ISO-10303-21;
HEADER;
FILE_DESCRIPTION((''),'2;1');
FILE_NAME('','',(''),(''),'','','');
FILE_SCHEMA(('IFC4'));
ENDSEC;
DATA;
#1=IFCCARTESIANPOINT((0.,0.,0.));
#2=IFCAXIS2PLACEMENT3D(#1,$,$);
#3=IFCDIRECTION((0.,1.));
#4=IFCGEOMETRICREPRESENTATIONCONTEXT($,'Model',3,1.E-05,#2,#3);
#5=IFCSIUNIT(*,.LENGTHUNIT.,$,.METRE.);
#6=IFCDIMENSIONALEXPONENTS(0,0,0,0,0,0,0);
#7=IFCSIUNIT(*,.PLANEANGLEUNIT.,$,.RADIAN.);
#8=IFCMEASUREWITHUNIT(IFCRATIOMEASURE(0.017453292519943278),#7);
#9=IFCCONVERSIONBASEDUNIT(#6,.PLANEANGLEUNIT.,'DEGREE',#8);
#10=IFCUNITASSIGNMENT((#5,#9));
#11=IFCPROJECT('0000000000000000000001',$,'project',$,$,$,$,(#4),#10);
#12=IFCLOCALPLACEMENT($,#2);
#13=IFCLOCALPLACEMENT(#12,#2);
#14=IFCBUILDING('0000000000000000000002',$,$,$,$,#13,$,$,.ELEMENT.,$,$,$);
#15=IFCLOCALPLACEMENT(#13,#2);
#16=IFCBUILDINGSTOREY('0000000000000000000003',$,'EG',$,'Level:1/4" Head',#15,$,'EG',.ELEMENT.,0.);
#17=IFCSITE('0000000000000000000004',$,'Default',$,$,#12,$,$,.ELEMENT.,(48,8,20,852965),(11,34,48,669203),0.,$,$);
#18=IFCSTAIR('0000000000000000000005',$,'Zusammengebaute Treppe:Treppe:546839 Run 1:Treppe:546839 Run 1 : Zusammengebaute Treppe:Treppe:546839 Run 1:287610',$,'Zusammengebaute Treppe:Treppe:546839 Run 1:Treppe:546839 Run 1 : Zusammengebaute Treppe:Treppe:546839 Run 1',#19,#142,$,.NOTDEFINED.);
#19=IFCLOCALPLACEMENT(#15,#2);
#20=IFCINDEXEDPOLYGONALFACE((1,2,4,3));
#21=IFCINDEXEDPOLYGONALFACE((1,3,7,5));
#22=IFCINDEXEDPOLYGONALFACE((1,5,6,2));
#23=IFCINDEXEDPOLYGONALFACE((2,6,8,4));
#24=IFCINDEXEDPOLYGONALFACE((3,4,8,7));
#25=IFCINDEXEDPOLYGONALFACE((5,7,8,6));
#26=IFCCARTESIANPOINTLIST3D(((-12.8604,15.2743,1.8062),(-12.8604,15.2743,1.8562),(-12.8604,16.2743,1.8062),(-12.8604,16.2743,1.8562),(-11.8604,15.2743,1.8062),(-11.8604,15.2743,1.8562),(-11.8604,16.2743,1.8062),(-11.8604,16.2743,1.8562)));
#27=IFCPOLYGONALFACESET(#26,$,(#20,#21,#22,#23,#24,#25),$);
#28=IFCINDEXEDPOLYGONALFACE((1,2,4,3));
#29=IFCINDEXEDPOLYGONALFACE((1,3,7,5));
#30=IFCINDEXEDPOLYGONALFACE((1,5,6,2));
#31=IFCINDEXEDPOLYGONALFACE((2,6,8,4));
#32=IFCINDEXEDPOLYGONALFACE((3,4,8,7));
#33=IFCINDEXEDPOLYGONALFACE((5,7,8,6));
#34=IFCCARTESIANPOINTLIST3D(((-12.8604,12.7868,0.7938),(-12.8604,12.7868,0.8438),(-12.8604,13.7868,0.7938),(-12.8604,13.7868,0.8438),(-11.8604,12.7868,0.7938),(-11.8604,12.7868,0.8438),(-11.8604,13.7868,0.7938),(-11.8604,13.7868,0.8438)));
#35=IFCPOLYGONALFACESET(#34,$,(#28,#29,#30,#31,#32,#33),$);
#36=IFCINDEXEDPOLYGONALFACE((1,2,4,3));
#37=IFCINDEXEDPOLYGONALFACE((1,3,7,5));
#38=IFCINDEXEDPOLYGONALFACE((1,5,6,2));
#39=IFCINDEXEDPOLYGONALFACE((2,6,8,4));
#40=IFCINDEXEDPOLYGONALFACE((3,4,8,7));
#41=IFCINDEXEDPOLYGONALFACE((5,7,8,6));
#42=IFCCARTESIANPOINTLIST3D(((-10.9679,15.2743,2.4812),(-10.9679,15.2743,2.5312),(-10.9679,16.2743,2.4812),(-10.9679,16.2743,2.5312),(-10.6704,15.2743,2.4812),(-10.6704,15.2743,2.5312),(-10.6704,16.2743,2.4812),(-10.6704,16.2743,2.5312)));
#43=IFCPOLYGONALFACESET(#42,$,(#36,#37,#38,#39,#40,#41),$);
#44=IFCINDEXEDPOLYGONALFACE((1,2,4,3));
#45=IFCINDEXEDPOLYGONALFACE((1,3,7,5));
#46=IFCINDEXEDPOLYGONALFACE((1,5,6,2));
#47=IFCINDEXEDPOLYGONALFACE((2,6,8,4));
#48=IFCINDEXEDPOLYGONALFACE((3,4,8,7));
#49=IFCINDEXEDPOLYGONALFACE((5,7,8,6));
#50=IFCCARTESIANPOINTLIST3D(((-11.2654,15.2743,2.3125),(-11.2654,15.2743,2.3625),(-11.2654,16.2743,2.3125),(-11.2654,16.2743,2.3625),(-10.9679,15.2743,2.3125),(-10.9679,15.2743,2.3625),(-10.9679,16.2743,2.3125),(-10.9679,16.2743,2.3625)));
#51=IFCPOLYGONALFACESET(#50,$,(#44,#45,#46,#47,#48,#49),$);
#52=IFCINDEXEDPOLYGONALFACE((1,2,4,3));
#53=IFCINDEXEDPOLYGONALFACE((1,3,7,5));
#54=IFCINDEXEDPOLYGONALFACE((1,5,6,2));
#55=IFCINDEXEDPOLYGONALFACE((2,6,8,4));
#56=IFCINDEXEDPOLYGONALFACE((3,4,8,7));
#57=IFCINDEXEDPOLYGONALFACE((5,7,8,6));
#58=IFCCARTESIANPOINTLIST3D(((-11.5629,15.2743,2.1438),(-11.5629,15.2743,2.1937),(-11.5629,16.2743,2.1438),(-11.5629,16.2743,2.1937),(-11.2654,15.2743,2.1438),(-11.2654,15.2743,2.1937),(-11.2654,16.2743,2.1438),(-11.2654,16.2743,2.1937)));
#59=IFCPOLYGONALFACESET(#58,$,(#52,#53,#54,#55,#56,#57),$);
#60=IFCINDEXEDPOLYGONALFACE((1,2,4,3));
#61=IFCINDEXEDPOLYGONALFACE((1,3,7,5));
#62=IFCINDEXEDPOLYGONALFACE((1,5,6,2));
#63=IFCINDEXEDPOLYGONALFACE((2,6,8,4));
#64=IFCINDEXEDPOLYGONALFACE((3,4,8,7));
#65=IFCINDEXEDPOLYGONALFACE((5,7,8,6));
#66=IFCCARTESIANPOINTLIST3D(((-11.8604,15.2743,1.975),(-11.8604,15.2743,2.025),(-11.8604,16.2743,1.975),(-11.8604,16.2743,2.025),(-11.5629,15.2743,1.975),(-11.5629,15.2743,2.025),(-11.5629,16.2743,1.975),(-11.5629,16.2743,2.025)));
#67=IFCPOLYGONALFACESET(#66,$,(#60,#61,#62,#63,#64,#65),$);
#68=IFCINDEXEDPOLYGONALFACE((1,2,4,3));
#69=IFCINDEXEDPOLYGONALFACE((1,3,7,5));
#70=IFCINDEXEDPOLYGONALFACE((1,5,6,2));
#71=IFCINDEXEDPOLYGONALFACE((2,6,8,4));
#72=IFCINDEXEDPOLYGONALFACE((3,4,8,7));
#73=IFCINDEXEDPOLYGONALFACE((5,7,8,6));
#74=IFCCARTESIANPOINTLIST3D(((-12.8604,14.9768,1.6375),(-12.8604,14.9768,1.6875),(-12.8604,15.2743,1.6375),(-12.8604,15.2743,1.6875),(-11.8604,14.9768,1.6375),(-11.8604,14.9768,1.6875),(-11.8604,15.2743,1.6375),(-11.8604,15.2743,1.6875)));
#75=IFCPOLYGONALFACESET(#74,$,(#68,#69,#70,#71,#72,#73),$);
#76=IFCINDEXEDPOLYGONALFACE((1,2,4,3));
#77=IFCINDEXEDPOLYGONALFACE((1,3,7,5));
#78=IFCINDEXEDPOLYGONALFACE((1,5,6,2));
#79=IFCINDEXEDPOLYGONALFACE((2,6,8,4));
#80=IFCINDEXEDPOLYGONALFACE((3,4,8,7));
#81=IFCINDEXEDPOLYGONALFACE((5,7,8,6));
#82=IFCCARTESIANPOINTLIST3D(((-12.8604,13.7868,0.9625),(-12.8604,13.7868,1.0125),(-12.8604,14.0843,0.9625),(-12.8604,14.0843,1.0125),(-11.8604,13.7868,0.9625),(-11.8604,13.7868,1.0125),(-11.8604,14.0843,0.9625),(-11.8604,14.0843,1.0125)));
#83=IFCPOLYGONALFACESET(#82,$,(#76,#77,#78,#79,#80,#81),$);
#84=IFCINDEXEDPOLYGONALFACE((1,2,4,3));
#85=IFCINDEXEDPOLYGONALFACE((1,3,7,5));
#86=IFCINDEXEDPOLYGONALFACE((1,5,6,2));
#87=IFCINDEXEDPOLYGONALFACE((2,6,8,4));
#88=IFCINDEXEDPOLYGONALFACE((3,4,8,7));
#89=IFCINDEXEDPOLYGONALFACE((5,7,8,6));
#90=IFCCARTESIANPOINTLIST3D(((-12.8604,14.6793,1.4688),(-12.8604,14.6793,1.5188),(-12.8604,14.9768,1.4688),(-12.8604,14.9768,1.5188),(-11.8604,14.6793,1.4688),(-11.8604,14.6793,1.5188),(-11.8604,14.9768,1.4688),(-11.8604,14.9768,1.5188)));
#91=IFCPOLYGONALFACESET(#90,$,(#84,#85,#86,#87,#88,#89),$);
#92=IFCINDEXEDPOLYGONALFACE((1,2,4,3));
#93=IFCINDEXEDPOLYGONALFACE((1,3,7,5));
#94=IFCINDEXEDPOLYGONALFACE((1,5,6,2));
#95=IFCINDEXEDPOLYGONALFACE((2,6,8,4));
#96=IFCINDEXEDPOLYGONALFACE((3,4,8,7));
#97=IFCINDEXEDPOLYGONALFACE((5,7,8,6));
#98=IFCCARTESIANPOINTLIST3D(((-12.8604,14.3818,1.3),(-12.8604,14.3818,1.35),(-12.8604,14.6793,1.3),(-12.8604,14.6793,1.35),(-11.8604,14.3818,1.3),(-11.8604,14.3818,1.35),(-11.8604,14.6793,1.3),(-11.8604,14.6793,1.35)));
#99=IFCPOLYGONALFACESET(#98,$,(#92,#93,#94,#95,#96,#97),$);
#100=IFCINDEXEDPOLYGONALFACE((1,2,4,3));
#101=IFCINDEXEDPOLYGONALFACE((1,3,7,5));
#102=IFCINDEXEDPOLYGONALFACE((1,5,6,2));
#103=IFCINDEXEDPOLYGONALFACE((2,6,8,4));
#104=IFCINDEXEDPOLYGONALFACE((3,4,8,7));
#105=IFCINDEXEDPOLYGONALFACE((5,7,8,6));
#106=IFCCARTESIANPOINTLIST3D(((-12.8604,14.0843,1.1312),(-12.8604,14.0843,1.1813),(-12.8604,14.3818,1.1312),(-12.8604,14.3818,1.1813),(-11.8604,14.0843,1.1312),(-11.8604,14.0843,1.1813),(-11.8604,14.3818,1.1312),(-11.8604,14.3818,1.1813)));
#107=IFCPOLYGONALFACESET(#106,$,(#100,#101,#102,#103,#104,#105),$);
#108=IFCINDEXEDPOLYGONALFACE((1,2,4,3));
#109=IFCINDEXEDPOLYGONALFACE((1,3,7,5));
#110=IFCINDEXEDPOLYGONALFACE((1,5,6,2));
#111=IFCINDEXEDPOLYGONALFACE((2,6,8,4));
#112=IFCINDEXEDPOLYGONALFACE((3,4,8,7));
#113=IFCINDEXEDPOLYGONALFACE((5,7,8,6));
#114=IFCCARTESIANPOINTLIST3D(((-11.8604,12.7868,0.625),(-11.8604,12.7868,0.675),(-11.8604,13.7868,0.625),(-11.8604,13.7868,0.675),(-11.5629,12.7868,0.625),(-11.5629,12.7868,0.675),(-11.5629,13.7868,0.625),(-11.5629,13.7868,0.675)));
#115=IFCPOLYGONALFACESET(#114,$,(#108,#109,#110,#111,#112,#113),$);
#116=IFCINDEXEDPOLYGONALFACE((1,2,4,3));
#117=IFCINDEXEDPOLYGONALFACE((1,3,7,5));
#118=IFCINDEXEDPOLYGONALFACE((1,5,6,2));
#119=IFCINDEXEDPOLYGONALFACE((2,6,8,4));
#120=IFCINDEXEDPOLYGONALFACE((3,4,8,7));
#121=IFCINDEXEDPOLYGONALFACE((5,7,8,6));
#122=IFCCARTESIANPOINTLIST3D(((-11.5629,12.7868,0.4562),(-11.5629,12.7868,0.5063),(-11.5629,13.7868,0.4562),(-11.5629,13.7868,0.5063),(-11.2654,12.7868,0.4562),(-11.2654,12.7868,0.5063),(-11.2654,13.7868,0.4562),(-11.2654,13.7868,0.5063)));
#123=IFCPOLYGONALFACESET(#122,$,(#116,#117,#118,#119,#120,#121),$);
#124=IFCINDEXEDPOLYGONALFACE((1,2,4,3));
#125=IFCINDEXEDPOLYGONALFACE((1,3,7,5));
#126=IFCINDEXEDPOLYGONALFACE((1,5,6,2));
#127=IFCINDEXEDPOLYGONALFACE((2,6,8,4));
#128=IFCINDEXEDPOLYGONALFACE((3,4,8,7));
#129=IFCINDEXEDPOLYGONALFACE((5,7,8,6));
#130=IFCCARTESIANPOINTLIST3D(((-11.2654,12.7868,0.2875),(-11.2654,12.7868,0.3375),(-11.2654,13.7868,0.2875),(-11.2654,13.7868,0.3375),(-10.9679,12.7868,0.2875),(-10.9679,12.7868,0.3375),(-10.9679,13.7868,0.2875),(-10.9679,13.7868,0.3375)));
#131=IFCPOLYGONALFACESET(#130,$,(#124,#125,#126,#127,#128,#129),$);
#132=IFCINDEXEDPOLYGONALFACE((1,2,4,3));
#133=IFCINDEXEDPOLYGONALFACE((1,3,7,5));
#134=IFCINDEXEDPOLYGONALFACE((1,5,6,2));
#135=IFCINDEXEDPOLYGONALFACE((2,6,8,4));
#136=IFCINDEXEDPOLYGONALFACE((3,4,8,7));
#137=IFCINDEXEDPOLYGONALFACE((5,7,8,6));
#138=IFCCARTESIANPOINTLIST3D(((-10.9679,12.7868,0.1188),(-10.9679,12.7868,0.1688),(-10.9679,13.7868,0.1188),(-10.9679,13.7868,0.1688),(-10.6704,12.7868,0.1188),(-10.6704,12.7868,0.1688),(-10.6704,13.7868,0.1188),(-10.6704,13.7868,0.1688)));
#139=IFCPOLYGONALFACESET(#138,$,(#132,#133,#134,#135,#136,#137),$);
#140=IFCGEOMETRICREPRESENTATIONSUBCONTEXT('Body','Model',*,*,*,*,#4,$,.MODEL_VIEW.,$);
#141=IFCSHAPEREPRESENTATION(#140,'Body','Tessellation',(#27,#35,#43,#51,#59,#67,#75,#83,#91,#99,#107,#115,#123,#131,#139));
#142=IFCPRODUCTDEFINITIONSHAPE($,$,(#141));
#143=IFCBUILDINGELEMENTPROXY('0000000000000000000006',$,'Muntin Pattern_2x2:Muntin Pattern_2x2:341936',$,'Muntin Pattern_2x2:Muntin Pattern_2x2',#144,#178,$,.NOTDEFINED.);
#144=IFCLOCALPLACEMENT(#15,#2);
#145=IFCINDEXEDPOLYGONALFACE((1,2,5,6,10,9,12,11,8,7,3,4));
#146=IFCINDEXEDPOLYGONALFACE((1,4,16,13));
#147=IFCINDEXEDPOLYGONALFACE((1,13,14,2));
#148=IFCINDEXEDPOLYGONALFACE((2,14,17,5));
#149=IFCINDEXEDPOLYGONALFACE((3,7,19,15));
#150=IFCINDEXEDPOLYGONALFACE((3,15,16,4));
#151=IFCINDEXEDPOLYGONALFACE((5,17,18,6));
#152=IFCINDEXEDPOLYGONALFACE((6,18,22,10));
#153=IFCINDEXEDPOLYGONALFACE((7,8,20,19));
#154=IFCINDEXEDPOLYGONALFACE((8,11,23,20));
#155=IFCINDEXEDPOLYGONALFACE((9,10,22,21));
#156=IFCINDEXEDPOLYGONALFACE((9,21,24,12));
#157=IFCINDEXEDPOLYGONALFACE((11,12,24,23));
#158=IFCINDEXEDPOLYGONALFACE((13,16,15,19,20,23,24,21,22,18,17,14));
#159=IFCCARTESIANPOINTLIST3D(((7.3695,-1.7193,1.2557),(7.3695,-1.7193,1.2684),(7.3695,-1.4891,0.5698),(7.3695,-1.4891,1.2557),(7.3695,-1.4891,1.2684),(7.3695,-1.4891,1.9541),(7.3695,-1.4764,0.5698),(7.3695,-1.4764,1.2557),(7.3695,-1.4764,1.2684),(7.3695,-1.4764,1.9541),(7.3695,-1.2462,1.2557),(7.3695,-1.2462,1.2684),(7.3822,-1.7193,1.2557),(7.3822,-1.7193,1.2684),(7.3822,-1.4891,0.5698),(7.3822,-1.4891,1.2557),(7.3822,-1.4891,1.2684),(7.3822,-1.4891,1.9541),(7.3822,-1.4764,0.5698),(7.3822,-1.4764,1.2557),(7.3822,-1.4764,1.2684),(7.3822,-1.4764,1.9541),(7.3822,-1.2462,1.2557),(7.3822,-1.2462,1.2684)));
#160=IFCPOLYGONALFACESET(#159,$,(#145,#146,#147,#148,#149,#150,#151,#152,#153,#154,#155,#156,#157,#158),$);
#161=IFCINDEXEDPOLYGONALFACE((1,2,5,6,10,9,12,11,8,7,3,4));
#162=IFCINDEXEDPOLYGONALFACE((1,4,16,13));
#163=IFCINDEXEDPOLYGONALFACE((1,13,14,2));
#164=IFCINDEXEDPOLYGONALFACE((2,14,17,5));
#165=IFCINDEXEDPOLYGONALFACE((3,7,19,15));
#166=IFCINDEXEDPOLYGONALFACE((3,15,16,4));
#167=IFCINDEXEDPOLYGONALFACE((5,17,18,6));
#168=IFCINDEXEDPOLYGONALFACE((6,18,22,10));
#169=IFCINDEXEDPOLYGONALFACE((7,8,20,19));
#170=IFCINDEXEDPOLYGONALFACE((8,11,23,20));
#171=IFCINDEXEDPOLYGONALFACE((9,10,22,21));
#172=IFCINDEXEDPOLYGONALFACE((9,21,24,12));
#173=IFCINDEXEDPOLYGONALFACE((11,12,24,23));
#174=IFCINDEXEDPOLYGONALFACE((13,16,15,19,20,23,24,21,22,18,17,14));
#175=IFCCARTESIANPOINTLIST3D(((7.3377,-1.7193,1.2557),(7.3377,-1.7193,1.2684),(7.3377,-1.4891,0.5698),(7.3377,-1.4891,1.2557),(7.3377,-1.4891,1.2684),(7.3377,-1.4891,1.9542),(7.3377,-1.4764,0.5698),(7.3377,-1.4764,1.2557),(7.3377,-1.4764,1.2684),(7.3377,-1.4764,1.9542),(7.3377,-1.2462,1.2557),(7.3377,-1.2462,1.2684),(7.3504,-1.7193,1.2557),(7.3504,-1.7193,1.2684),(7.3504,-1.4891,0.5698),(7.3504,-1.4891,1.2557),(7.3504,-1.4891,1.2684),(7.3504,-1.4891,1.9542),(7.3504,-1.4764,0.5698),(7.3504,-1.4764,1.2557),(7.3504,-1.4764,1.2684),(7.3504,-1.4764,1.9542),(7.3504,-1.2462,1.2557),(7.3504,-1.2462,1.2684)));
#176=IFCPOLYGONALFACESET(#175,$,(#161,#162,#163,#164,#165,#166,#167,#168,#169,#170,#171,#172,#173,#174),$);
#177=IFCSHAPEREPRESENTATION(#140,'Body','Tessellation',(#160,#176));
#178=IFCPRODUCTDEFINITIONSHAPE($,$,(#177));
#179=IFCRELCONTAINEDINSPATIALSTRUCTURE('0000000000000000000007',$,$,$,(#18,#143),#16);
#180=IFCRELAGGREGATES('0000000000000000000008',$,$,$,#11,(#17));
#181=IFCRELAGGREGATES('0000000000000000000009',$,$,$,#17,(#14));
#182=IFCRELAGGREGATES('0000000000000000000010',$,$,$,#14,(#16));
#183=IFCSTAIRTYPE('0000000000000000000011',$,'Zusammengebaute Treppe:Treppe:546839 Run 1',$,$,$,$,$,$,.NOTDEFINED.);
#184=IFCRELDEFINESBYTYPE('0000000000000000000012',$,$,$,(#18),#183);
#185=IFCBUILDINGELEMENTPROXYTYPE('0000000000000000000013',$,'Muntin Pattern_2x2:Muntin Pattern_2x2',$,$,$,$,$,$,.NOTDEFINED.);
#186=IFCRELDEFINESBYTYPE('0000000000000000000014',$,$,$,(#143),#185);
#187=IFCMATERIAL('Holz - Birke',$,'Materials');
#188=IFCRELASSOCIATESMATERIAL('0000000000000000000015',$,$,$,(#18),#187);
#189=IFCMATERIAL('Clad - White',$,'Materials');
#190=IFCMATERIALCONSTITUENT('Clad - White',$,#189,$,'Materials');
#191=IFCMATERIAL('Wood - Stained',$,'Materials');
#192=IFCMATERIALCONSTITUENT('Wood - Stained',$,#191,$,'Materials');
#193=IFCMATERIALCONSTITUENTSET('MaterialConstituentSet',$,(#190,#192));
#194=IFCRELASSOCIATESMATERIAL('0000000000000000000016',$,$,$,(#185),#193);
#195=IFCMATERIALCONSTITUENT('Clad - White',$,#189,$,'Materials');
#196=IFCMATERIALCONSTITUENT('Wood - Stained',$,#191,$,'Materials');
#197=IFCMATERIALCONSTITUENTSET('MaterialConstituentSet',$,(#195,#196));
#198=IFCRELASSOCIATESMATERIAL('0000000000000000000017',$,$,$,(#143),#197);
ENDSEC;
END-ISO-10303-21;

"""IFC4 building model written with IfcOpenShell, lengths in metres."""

from ifc_helpers import new_model, entity, si_unit, converted_unit, direction, frame, origin, place, context, subcontext, project, spatial, indexed_curve, outline, extrude, source, transform, mapped, material, constituent, constituent_set, type_object, type_shapes, element, save


model = new_model("IFC4")

# Units and contexts
model_context = context("Model", 3, precision=1e-05, world=origin(), true_north=direction((0.0, 1.0)))
body_context = subcontext(model_context, "Body", "Model", "MODEL_VIEW")
ifc_project = project(units=[si_unit("LENGTHUNIT", "METRE"), converted_unit("PLANEANGLEUNIT", "DEGREE", entity("IfcRatioMeasure", 0.017453292519943278), si_unit("PLANEANGLEUNIT", "RADIAN"), dimensions=[0, 0, 0, 0, 0, 0, 0])], contexts=[model_context])

# Site, building, storey
site_placement = place(None, origin())
site = spatial("IfcSite", under=ifc_project, at=site_placement, Name="Default", CompositionType="ELEMENT", RefLatitude=(48, 8, 20, 852965), RefLongitude=(11, 34, 48, 669203), RefElevation=0.0)
building_placement = place(site_placement, origin())
building = spatial("IfcBuilding", under=site, at=building_placement, CompositionType="ELEMENT")
storey_placement = place(building_placement, origin())
storey = spatial("IfcBuildingStorey", under=building, at=storey_placement, Name="EG", ObjectType="Level:1/4\" Head", LongName="EG", CompositionType="ELEMENT", Elevation=0.0)

# Stair
ifc_material_1 = material(Name="Holz - Birke", Category="Materials")
stair_type_1 = type_object("IfcStairType", Name="Zusammengebaute Treppe:Treppe:546839 Run 1", PredefinedType="NOTDEFINED")
stair_1_placement = place(storey_placement, origin())
element("IfcStair", 1, at=stair_1_placement, inside=storey, type_object=stair_type_1, material=ifc_material_1, Name="Zusammengebaute Treppe:Treppe:546839 Run 1:Treppe:546839 Run 1 : Zusammengebaute Treppe:Treppe:546839 Run 1:287610", ObjectType="Zusammengebaute Treppe:Treppe:546839 Run 1:Treppe:546839 Run 1 : Zusammengebaute Treppe:Treppe:546839 Run 1", PredefinedType="NOTDEFINED", context=body_context, shape_type="SweptSolid", body=[
    extrude(outline(indexed_curve([(-0.5, -0.5), (0.5, -0.5), (0.5, 0.5), (-0.5, 0.5), (-0.5, -0.5)], self_intersect=False)), frame((-12.3604, 15.7743, 1.8063), z_axis=(0.0, 0.0, 1.0), x_axis=(0.0, 1.0, 0.0)), (0.0, 0.0, 1.0), 0.05),
    extrude(outline(indexed_curve([(-0.5, -0.5), (0.5, -0.5), (0.5, 0.5), (-0.5, 0.5), (-0.5, -0.5)], self_intersect=False)), frame((-12.3604, 13.2868, 0.7938), z_axis=(0.0, 0.0, 1.0), x_axis=(-1.0, 0.0, 0.0)), (0.0, 0.0, 1.0), 0.05),
    extrude(outline(indexed_curve([(-0.5, -0.1487), (0.5, -0.1487), (0.5, 0.1487), (-0.5, 0.1487), (-0.5, -0.1487)], self_intersect=False)), frame((-10.8191, 15.7743, 2.4813), z_axis=(0.0, 0.0, 1.0), x_axis=(0.0, -1.0, 0.0)), (0.0, 0.0, 1.0), 0.05),
    extrude(outline(indexed_curve([(-0.5, -0.1487), (0.5, -0.1487), (0.5, 0.1487), (-0.5, 0.1487), (-0.5, -0.1487)], self_intersect=False)), frame((-11.1166, 15.7743, 2.3125), z_axis=(0.0, 0.0, 1.0), x_axis=(0.0, -1.0, 0.0)), (0.0, 0.0, 1.0), 0.05),
    extrude(outline(indexed_curve([(-0.5, -0.1487), (0.5, -0.1487), (0.5, 0.1487), (-0.5, 0.1487), (-0.5, -0.1487)], self_intersect=False)), frame((-11.4141, 15.7743, 2.1437), z_axis=(0.0, 0.0, 1.0), x_axis=(0.0, -1.0, 0.0)), (0.0, 0.0, 1.0), 0.05),
    extrude(outline(indexed_curve([(-0.5, -0.1488), (0.5, -0.1488), (0.5, 0.1488), (-0.5, 0.1488), (-0.5, -0.1488)], self_intersect=False)), frame((-11.7116, 15.7743, 1.975), z_axis=(0.0, 0.0, 1.0), x_axis=(0.0, -1.0, 0.0)), (0.0, 0.0, 1.0), 0.05),
    extrude(outline(indexed_curve([(-0.5, -0.1487), (0.5, -0.1487), (0.5, 0.1488), (-0.5, 0.1488), (-0.5, -0.1487)], self_intersect=False)), frame((-12.3604, 15.1256, 1.6375)), (0.0, 0.0, 1.0), 0.05),
    extrude(outline(indexed_curve([(-0.5, -0.1487), (0.5, -0.1487), (0.5, 0.1488), (-0.5, 0.1488), (-0.5, -0.1487)], self_intersect=False)), frame((-12.3604, 13.9356, 0.9625)), (0.0, 0.0, 1.0), 0.05),
    extrude(outline(indexed_curve([(-0.5, -0.1487), (0.5, -0.1487), (0.5, 0.1488), (-0.5, 0.1488), (-0.5, -0.1487)], self_intersect=False)), frame((-12.3604, 14.8281, 1.4688)), (0.0, 0.0, 1.0), 0.05),
    extrude(outline(indexed_curve([(-0.5, -0.1487), (0.5, -0.1487), (0.5, 0.1488), (-0.5, 0.1488), (-0.5, -0.1487)], self_intersect=False)), frame((-12.3604, 14.5306, 1.3)), (0.0, 0.0, 1.0), 0.05),
    extrude(outline(indexed_curve([(-0.5, -0.1488), (0.5, -0.1488), (0.5, 0.1487), (-0.5, 0.1487), (-0.5, -0.1488)], self_intersect=False)), frame((-12.3604, 14.2331, 1.1313)), (0.0, 0.0, 1.0), 0.05),
    extrude(outline(indexed_curve([(-0.5, -0.1487), (0.5, -0.1487), (0.5, 0.1487), (-0.5, 0.1487), (-0.5, -0.1487)], self_intersect=False)), frame((-11.7116, 13.2868, 0.625), z_axis=(0.0, 0.0, 1.0), x_axis=(0.0, 1.0, 0.0)), (0.0, 0.0, 1.0), 0.05),
    extrude(outline(indexed_curve([(-0.5, -0.1487), (0.5, -0.1487), (0.5, 0.1487), (-0.5, 0.1487), (-0.5, -0.1487)], self_intersect=False)), frame((-11.4141, 13.2868, 0.4563), z_axis=(0.0, 0.0, 1.0), x_axis=(0.0, 1.0, 0.0)), (0.0, 0.0, 1.0), 0.05),
    extrude(outline(indexed_curve([(-0.5, -0.1487), (0.5, -0.1487), (0.5, 0.1487), (-0.5, 0.1487), (-0.5, -0.1487)], self_intersect=False)), frame((-11.1166, 13.2868, 0.2875), z_axis=(0.0, 0.0, 1.0), x_axis=(0.0, 1.0, 0.0)), (0.0, 0.0, 1.0), 0.05),
    extrude(outline(indexed_curve([(-0.5, -0.1488), (0.5, -0.1488), (0.5, 0.1488), (-0.5, 0.1488), (-0.5, -0.1488)], self_intersect=False)), frame((-10.8191, 13.2868, 0.1188), z_axis=(0.0, 0.0, 1.0), x_axis=(0.0, 1.0, 0.0)), (0.0, 0.0, 1.0), 0.05),
])

# Building element proxy
ifc_material_2 = material(Name="Clad - White", Category="Materials")
ifc_constituent_1 = constituent(ifc_material_2, Name="Clad - White", Category="Materials")
ifc_material_3 = material(Name="Wood - Stained", Category="Materials")
ifc_constituent_2 = constituent(ifc_material_3, Name="Wood - Stained", Category="Materials")
ifc_constituent_set_1 = constituent_set(constituents=[ifc_constituent_1, ifc_constituent_2], Name="MaterialConstituentSet")
ifc_constituent_3 = constituent(ifc_material_2, Name="Clad - White", Category="Materials")
ifc_constituent_4 = constituent(ifc_material_3, Name="Wood - Stained", Category="Materials")
ifc_constituent_set_2 = constituent_set(constituents=[ifc_constituent_3, ifc_constituent_4], Name="MaterialConstituentSet")
building_element_proxy_type_1 = type_object("IfcBuildingElementProxyType", Name="Muntin Pattern_2x2:Muntin Pattern_2x2", PredefinedType="NOTDEFINED", material=ifc_constituent_set_2)
shared_shape_1 = source(origin(), body_context, "Body", "SweptSolid", [
    extrude(outline(indexed_curve([(0.0064, -0.0064), (0.6921, -0.0064), (0.6921, 0.0063), (0.0064, 0.0063), (0.0064, 0.2365), (-0.0063, 0.2365), (-0.0063, 0.0063), (-0.6922, 0.0063), (-0.6922, -0.0064), (-0.0063, -0.0064), (-0.0063, -0.2365), (0.0064, -0.2365), (0.0064, -0.0064)], self_intersect=False)), frame((0.0, -0.0222, 0.6921), z_axis=(0.0, 1.0, 0.0), x_axis=(0.0, 0.0, 1.0)), (0.0, 0.0, 1.0), 0.0127),
    extrude(outline(indexed_curve([(0.0064, -0.0064), (0.6922, -0.0064), (0.6922, 0.0063), (0.0064, 0.0063), (0.0064, 0.2365), (-0.0063, 0.2365), (-0.0063, 0.0063), (-0.6922, 0.0063), (-0.6922, -0.0064), (-0.0063, -0.0064), (-0.0063, -0.2365), (0.0064, -0.2365), (0.0064, -0.0064)], self_intersect=False)), frame((0.0, 0.0095, 0.6922), z_axis=(0.0, 1.0, 0.0), x_axis=(0.0, 0.0, 1.0)), (0.0, 0.0, 1.0), 0.0127),
])
type_shapes(building_element_proxy_type_1, [shared_shape_1])
proxy_1_placement = place(storey_placement, frame((7.3599, -1.4828, 0.5699), z_axis=(0.0, 0.0, 1.0), x_axis=(0.0, 1.0, 0.0)))
element("IfcBuildingElementProxy", 2, at=proxy_1_placement, inside=storey, type_object=building_element_proxy_type_1, material=ifc_constituent_set_1, Name="Muntin Pattern_2x2:Muntin Pattern_2x2:341936", ObjectType="Muntin Pattern_2x2:Muntin Pattern_2x2", PredefinedType="NOTDEFINED", context=body_context, shape_type="MappedRepresentation", body=[
    mapped(shared_shape_1, transform((0.0, 0.0, 0.0), scale=1.0)),
])

save(model, "model.ifc")
